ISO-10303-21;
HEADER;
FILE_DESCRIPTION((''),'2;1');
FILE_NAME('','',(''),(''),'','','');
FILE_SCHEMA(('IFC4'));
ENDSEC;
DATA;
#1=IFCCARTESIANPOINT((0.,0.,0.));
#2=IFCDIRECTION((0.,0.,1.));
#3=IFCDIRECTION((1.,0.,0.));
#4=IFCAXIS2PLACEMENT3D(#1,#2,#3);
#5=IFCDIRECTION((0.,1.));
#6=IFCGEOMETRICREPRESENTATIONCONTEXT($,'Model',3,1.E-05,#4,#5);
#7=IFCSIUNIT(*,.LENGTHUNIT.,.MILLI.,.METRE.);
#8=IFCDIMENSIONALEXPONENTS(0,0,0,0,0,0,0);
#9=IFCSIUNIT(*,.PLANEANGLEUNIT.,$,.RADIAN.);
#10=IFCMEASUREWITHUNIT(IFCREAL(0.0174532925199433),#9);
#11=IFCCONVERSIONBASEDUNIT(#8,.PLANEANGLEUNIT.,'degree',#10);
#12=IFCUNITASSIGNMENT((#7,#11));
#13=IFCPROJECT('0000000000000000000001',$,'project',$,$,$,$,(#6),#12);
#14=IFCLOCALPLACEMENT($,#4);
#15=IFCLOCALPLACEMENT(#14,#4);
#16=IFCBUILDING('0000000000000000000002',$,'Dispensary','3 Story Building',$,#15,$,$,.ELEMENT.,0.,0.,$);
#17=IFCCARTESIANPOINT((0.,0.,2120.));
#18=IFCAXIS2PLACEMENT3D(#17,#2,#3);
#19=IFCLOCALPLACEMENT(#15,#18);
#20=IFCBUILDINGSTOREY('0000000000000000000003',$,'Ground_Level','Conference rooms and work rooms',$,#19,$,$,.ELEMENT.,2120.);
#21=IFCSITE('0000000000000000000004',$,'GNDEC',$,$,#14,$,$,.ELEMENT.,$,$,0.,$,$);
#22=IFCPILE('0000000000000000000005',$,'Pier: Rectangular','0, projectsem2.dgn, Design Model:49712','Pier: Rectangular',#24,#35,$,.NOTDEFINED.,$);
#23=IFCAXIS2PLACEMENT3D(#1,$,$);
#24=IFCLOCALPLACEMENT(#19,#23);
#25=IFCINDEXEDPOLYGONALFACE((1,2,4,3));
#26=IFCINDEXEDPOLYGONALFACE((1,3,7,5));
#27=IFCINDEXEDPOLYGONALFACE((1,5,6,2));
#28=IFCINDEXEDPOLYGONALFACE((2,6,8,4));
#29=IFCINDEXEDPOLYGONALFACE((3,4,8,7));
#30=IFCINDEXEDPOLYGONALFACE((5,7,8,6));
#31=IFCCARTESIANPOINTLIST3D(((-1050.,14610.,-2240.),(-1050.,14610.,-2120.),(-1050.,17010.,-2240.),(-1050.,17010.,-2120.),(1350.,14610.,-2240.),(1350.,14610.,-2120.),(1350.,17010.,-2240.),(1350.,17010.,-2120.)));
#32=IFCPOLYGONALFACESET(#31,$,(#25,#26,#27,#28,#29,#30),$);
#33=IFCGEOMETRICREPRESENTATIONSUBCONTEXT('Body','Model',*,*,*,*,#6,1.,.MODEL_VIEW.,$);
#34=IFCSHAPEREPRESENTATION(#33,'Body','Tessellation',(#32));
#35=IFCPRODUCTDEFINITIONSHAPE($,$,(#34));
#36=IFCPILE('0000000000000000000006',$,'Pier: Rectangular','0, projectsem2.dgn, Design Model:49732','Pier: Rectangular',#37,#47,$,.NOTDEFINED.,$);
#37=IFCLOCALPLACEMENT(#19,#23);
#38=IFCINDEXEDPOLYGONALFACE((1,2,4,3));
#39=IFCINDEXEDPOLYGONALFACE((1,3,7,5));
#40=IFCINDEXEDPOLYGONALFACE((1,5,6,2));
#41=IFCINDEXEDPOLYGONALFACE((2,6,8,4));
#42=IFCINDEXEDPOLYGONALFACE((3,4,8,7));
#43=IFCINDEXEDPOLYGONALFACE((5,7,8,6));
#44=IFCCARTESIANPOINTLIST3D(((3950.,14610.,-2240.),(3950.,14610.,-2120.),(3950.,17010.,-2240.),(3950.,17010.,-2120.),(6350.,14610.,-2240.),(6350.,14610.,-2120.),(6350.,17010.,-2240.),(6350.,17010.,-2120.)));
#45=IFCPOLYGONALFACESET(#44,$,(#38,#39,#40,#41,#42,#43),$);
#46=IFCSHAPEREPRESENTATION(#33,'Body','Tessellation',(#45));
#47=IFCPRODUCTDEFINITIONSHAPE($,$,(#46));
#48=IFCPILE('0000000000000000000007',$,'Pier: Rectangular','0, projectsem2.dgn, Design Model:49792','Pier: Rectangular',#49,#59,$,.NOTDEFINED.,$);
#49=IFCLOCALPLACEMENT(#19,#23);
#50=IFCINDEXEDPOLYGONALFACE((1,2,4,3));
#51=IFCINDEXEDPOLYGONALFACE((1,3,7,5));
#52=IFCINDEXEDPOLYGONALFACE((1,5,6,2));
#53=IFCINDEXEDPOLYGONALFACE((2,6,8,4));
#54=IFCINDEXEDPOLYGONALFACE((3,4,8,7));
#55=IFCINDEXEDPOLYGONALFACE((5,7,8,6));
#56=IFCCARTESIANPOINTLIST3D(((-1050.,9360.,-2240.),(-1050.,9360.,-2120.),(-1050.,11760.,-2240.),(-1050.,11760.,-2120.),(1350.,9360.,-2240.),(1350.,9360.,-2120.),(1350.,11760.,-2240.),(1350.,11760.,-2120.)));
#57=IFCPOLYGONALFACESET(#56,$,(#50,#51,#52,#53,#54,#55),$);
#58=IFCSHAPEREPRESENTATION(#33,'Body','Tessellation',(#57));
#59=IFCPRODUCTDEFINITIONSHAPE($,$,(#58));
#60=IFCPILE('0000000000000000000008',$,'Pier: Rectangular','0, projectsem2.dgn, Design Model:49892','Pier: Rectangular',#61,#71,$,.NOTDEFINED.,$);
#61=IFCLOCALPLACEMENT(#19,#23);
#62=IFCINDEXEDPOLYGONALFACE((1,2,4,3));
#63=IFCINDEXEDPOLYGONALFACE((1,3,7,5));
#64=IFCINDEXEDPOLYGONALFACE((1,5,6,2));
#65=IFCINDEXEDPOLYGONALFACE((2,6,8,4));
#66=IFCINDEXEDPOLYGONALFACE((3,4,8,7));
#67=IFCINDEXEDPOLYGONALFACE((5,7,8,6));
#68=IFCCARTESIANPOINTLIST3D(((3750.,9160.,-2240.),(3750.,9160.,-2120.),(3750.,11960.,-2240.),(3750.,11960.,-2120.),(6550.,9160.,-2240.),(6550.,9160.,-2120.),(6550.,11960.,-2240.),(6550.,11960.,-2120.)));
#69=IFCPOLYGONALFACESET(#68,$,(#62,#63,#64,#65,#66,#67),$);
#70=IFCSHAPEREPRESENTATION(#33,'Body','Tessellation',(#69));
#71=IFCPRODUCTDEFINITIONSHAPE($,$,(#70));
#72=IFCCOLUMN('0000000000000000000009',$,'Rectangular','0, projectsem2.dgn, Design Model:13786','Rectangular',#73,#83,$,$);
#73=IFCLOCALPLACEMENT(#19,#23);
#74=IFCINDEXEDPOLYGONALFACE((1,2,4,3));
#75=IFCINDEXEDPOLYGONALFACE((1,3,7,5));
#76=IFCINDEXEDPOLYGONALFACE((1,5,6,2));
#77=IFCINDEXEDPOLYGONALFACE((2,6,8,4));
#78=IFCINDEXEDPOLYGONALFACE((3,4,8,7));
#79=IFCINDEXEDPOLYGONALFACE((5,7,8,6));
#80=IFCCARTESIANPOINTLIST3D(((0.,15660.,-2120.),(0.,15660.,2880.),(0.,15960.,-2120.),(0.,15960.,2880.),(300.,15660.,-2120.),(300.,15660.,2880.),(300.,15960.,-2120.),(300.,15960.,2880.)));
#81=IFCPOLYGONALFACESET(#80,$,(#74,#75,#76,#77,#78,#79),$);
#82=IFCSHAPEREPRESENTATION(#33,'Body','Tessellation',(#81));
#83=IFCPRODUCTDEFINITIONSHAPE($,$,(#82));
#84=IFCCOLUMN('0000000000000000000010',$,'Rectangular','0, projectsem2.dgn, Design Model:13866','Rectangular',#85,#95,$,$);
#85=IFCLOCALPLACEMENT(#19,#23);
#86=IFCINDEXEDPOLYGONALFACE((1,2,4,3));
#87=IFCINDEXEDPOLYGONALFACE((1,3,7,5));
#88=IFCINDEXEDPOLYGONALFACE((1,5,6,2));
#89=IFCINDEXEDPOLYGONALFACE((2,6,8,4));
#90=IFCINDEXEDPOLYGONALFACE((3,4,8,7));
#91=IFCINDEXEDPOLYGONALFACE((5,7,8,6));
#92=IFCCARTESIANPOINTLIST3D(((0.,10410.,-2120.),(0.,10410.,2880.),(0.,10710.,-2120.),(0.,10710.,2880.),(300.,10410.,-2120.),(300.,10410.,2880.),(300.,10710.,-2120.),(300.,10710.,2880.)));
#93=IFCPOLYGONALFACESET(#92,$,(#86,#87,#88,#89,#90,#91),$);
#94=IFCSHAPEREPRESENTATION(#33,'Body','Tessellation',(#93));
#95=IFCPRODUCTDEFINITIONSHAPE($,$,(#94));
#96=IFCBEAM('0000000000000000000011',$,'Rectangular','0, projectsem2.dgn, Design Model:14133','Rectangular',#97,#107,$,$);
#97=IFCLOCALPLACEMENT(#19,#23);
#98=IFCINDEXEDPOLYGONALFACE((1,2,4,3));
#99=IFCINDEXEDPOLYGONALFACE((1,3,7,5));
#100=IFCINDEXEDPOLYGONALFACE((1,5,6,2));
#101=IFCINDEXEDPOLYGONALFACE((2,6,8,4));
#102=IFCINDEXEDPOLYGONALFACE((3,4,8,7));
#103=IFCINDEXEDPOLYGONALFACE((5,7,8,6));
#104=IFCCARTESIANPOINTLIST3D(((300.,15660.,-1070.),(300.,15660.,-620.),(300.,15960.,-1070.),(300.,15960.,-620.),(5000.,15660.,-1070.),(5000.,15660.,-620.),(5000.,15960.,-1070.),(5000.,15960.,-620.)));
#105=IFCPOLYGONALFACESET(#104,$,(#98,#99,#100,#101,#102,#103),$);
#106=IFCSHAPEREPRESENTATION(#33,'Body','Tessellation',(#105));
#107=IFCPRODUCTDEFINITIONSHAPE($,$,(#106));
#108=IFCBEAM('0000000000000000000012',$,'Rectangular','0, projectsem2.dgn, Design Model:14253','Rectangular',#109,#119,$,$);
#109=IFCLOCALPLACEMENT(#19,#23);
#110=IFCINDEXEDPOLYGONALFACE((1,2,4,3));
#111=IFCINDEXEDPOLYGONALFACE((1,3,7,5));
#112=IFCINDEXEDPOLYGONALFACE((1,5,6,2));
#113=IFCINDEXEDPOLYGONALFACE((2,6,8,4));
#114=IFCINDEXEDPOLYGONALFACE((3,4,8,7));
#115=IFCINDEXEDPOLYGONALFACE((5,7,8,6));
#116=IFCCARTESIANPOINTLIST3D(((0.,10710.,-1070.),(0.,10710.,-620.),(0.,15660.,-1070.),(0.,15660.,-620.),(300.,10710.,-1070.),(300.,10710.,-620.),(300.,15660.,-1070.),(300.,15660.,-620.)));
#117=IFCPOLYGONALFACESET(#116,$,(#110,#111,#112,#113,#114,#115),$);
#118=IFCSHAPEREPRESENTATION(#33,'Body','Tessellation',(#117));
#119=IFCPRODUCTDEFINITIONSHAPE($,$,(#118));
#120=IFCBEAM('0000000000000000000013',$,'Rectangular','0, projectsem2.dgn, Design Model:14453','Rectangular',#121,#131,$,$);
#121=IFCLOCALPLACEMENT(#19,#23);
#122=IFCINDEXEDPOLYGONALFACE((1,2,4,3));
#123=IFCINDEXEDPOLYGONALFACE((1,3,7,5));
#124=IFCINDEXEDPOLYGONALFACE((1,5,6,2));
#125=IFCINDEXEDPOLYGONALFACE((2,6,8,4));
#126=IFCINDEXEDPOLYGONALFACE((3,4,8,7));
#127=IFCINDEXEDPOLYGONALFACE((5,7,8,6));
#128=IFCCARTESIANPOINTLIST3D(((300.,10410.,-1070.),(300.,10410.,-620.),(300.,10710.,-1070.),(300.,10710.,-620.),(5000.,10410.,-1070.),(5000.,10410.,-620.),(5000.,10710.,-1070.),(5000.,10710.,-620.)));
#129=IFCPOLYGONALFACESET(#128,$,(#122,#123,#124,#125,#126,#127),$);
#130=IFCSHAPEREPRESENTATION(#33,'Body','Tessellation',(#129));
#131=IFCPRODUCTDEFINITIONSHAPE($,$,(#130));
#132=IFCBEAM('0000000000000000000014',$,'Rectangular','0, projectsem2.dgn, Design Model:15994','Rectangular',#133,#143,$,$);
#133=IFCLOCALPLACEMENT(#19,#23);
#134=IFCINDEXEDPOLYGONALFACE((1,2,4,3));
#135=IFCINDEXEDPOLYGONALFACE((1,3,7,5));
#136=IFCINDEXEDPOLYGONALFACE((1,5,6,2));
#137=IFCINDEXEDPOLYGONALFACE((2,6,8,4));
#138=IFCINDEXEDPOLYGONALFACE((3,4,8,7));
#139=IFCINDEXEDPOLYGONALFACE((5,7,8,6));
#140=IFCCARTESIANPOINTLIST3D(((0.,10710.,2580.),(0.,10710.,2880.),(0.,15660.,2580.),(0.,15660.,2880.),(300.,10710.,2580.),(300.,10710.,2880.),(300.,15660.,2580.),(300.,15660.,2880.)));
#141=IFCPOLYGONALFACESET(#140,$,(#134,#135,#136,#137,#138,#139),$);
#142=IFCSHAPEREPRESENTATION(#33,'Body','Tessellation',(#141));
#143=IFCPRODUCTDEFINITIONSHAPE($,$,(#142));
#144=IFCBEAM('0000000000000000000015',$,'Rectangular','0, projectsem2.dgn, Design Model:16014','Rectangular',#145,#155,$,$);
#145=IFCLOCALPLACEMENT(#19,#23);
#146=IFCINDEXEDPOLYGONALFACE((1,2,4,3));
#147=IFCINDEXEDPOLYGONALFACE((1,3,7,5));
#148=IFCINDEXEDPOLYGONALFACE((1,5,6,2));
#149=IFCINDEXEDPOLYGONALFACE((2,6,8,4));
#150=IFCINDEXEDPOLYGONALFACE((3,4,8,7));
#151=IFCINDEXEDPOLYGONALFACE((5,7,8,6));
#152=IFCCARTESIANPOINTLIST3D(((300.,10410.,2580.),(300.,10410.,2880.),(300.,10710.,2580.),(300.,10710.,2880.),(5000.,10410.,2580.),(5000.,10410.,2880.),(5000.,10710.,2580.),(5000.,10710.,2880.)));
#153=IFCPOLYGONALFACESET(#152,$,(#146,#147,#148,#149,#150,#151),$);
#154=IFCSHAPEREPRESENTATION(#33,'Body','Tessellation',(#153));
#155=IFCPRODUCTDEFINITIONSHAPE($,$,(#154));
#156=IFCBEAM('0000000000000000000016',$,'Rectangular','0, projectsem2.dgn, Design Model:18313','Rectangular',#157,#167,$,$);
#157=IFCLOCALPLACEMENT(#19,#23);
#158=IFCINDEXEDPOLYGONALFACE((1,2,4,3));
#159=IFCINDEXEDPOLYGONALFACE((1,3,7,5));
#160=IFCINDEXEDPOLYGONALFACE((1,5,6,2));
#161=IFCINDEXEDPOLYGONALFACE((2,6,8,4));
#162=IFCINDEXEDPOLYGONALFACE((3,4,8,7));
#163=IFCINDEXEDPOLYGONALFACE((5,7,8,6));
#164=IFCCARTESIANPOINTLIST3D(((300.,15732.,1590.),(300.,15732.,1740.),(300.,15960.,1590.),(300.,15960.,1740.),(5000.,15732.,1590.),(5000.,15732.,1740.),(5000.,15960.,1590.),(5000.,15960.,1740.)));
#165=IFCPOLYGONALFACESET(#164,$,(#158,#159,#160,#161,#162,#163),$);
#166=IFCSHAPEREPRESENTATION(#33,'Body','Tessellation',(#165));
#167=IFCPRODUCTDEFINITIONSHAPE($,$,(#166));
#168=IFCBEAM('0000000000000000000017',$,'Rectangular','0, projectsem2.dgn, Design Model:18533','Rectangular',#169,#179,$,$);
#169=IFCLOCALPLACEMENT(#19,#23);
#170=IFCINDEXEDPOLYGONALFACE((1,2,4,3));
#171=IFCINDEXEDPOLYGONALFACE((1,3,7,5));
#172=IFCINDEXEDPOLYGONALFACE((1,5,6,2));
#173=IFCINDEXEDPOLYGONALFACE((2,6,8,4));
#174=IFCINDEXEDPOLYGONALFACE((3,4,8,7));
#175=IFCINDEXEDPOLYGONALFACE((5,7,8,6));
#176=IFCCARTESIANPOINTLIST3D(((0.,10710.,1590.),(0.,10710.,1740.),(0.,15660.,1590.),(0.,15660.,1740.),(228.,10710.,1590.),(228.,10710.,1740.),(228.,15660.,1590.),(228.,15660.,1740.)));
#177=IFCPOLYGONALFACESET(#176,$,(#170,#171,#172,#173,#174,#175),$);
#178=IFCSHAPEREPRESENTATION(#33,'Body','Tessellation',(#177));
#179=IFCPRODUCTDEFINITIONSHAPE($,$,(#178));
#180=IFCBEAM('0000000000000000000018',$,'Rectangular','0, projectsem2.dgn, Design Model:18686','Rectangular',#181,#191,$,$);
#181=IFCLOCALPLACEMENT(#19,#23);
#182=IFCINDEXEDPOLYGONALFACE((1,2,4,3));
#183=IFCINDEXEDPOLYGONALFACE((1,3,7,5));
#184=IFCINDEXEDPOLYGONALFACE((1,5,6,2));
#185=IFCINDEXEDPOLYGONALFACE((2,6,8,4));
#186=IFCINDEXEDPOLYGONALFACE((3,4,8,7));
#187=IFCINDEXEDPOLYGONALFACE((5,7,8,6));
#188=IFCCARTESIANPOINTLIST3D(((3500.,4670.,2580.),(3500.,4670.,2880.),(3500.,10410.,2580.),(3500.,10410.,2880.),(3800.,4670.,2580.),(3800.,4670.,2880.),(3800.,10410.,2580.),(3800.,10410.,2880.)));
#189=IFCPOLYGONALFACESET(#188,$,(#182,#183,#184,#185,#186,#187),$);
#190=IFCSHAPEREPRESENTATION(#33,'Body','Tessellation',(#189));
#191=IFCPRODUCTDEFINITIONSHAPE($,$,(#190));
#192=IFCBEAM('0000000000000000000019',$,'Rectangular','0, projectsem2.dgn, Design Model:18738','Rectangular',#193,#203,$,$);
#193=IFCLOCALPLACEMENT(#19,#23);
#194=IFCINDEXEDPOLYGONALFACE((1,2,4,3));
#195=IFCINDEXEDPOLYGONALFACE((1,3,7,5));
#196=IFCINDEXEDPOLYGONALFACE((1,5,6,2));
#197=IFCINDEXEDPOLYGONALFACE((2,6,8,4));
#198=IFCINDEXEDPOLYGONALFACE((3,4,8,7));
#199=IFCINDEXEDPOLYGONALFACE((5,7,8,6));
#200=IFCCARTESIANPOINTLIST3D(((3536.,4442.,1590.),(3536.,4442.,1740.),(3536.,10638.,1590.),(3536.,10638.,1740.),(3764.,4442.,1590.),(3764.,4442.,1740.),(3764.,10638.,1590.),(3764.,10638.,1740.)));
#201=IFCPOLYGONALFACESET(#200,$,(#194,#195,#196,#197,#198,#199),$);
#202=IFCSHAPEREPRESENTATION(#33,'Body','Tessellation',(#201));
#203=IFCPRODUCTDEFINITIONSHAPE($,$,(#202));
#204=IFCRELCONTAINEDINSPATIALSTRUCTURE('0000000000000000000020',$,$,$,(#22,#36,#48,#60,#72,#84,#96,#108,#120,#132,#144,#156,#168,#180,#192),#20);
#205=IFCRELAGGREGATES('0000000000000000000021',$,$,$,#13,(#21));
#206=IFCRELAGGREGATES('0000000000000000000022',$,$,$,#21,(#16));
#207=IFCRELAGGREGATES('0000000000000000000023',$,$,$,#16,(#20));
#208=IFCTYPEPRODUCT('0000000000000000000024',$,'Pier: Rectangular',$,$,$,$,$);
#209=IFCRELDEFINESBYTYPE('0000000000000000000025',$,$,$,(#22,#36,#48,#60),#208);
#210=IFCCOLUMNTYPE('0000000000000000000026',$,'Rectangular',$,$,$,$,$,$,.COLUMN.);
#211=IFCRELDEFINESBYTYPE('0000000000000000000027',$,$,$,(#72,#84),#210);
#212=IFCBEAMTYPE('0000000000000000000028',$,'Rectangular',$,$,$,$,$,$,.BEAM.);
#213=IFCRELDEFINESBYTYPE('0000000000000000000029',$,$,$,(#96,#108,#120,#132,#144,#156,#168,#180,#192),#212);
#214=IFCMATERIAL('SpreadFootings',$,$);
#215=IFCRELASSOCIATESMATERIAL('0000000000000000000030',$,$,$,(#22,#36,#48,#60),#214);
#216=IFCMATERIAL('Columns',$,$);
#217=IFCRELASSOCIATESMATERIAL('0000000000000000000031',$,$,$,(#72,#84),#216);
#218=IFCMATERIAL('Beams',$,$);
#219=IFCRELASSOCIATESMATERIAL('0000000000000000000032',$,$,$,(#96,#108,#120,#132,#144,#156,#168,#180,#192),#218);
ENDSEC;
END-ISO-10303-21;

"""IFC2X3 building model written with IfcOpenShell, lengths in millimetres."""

from ifc_helpers import new_model, entity, si_unit, converted_unit, direction, frame, frame_2d, origin_with_axes, place, context, subcontext, project, spatial, rectangle, extrude, material, type_object, element, save


model = new_model("IFC2X3")

# Units and contexts
model_context = context("Model", 3, precision=1e-05, world=origin_with_axes(), true_north=direction((0.0, 1.0)))
body_context = subcontext(model_context, "Body", "Model", "MODEL_VIEW", scale=1.0)
ifc_project = project(units=[si_unit("LENGTHUNIT", "METRE", prefix="MILLI"), converted_unit("PLANEANGLEUNIT", "degree", entity("IfcReal", 0.0174532925199433), si_unit("PLANEANGLEUNIT", "RADIAN"), dimensions=[0, 0, 0, 0, 0, 0, 0])], contexts=[model_context])

# Site, building, storey
site_placement = place(None, origin_with_axes())
site = spatial("IfcSite", under=ifc_project, at=site_placement, Name="GNDEC", CompositionType="ELEMENT", RefElevation=0.0)
building_placement = place(site_placement, origin_with_axes())
building = spatial("IfcBuilding", under=site, at=building_placement, Name="Dispensary", Description="3 Story Building", CompositionType="ELEMENT", ElevationOfRefHeight=0.0, ElevationOfTerrain=0.0)
storey_placement = place(building_placement, frame((0.0, 0.0, 2120.0), z_axis=(0.0, 0.0, 1.0), x_axis=(1.0, 0.0, 0.0)))
storey = spatial("IfcBuildingStorey", under=building, at=storey_placement, Name="Ground_Level", Description="Conference rooms and work rooms", CompositionType="ELEMENT", Elevation=2120.0)

# Piles
ifc_material_1 = material(Name="SpreadFootings")
type_product = type_object("IfcTypeProduct", Name="Pier: Rectangular")
for number, where, z_axis, x_axis, name, description in (
    (1, (-1050.0, 17010.0, -2240.0), (0.0, 0.0, 1.0), (0.0, -1.0, 0.0), "Pier: Rectangular", "0, projectsem2.dgn, Design Model:49712"),
    (2, (3950.0, 17010.0, -2240.0), (0.0, 0.0, 1.0), (0.0, -1.0, 0.0), "Pier: Rectangular", "0, projectsem2.dgn, Design Model:49732"),
    (3, (-1050.0, 11760.0, -2240.0), (0.0, 0.0, 1.0), (0.0, -1.0, 0.0), "Pier: Rectangular", "0, projectsem2.dgn, Design Model:49792"),
):
    element("IfcPile", number, at=place(storey_placement, frame(where, z_axis=z_axis, x_axis=x_axis)), inside=storey, type_object=type_product, material=ifc_material_1, Name=name, Description=description, ObjectType="Pier: Rectangular", PredefinedType="NOTDEFINED", context=body_context, shape_type="SweptSolid", body=[
        extrude(rectangle(XDim=2400.0, YDim=2400.0, at=frame_2d((1200.0, 1200.0), x_axis=(0.0, 1.0))), origin_with_axes(), (0.0, 0.0, 1.0), 120.0),
    ])
pile_placement = place(storey_placement, frame((3750.0, 11960.0, -2240.0), z_axis=(0.0, 0.0, 1.0), x_axis=(0.0, -1.0, 0.0)))
element("IfcPile", 4, at=pile_placement, inside=storey, type_object=type_product, material=ifc_material_1, Name="Pier: Rectangular", Description="0, projectsem2.dgn, Design Model:49892", ObjectType="Pier: Rectangular", PredefinedType="NOTDEFINED", context=body_context, shape_type="SweptSolid", body=[
    extrude(rectangle(XDim=2800.0, YDim=2800.0, at=frame_2d((1400.0, 1400.0), x_axis=(0.0, 1.0))), origin_with_axes(), (0.0, 0.0, 1.0), 120.0),
])

# Columns
ifc_material_2 = material(Name="Columns")
column_type = type_object("IfcColumnType", Name="Rectangular", PredefinedType="COLUMN")
for number, where, z_axis, x_axis, name, description in (
    (5, (0.0, 15960.0, -2120.0), (0.0, 0.0, 1.0), (0.0, -1.0, 0.0), "Rectangular", "0, projectsem2.dgn, Design Model:13786"),
    (6, (0.0, 10710.0, -2120.0), (0.0, 0.0, 1.0), (0.0, -1.0, 0.0), "Rectangular", "0, projectsem2.dgn, Design Model:13866"),
):
    element("IfcColumn", number, at=place(storey_placement, frame(where, z_axis=z_axis, x_axis=x_axis)), inside=storey, type_object=column_type, material=ifc_material_2, Name=name, Description=description, ObjectType="Rectangular", context=body_context, shape_type="SweptSolid", body=[
        extrude(rectangle(XDim=300.0, YDim=300.0, at=frame_2d((150.0, 150.0), x_axis=(0.0, 1.0))), origin_with_axes(), (0.0, 0.0, 1.0), 5000.0),
    ])

# Beams
ifc_material_3 = material(Name="Beams")
beam_type = type_object("IfcBeamType", Name="Rectangular", PredefinedType="BEAM")
beam_1_placement = place(storey_placement, frame((300.0, 15960.0, -1070.0), z_axis=(1.0, 0.0, 0.0), x_axis=(0.0, 0.0, 1.0)))
element("IfcBeam", 7, at=beam_1_placement, inside=storey, type_object=beam_type, material=ifc_material_3, Name="Rectangular", Description="0, projectsem2.dgn, Design Model:14133", ObjectType="Rectangular", context=body_context, shape_type="SweptSolid", body=[
    extrude(rectangle(XDim=300.0, YDim=450.0, at=frame_2d((225.0, 150.0), x_axis=(0.0, 1.0))), origin_with_axes(), (0.0, 0.0, 1.0), 4700.0),
])
beam_2_placement = place(storey_placement, frame((300.0, 15660.0, -1070.0), z_axis=(0.0, -1.0, 0.0), x_axis=(0.0, 0.0, 1.0)))
element("IfcBeam", 8, at=beam_2_placement, inside=storey, type_object=beam_type, material=ifc_material_3, Name="Rectangular", Description="0, projectsem2.dgn, Design Model:14253", ObjectType="Rectangular", context=body_context, shape_type="SweptSolid", body=[
    extrude(rectangle(XDim=300.0, YDim=450.0, at=frame_2d((225.0, 150.0), x_axis=(0.0, 1.0))), origin_with_axes(), (0.0, 0.0, 1.0), 4950.0),
])
beam_3_placement = place(storey_placement, frame((5000.0, 10410.0, -1070.0), z_axis=(-1.0, 0.0, 0.0), x_axis=(0.0, 0.0, 1.0)))
element("IfcBeam", 9, at=beam_3_placement, inside=storey, type_object=beam_type, material=ifc_material_3, Name="Rectangular", Description="0, projectsem2.dgn, Design Model:14453", ObjectType="Rectangular", context=body_context, shape_type="SweptSolid", body=[
    extrude(rectangle(XDim=300.0, YDim=450.0, at=frame_2d((225.0, 150.0), x_axis=(0.0, 1.0))), origin_with_axes(), (0.0, 0.0, 1.0), 4700.0),
])
beam_4_placement = place(storey_placement, frame((300.0, 15660.0, 2580.0), z_axis=(0.0, -1.0, 0.0), x_axis=(0.0, 0.0, 1.0)))
element("IfcBeam", 10, at=beam_4_placement, inside=storey, type_object=beam_type, material=ifc_material_3, Name="Rectangular", Description="0, projectsem2.dgn, Design Model:15994", ObjectType="Rectangular", context=body_context, shape_type="SweptSolid", body=[
    extrude(rectangle(XDim=300.0, YDim=300.0, at=frame_2d((150.0, 150.0), x_axis=(0.0, 1.0))), origin_with_axes(), (0.0, 0.0, 1.0), 4950.0),
])
for number, where, z_axis, x_axis, name in (
    (11, (300.0, 10710.0, 2580.0), (1.0, 0.0, 0.0), (0.0, 0.0, 1.0), "Rectangular"),
):
    element("IfcBeam", number, at=place(storey_placement, frame(where, z_axis=z_axis, x_axis=x_axis)), inside=storey, type_object=beam_type, material=ifc_material_3, Name=name, Description="0, projectsem2.dgn, Design Model:16014", ObjectType="Rectangular", context=body_context, shape_type="SweptSolid", body=[
        extrude(rectangle(XDim=300.0, YDim=300.0, at=frame_2d((150.0, 150.0), x_axis=(0.0, 1.0))), origin_with_axes(), (0.0, 0.0, 1.0), 4700.0),
    ])
beam_5_placement = place(storey_placement, frame((300.0, 15732.0, 1590.0), z_axis=(1.0, 0.0, 0.0), x_axis=(0.0, 1.0, 0.0)))
element("IfcBeam", 12, at=beam_5_placement, inside=storey, type_object=beam_type, material=ifc_material_3, Name="Rectangular", Description="0, projectsem2.dgn, Design Model:18313", ObjectType="Rectangular", context=body_context, shape_type="SweptSolid", body=[
    extrude(rectangle(XDim=150.0, YDim=228.0, at=frame_2d((114.0, 75.0), x_axis=(0.0, 1.0))), origin_with_axes(), (0.0, 0.0, 1.0), 4700.0),
])
beam_6_placement = place(storey_placement, frame((0.0, 15660.0, 1590.0), z_axis=(0.0, -1.0, 0.0), x_axis=(1.0, 0.0, 0.0)))
element("IfcBeam", 13, at=beam_6_placement, inside=storey, type_object=beam_type, material=ifc_material_3, Name="Rectangular", Description="0, projectsem2.dgn, Design Model:18533", ObjectType="Rectangular", context=body_context, shape_type="SweptSolid", body=[
    extrude(rectangle(XDim=150.0, YDim=228.0, at=frame_2d((114.0, 75.0), x_axis=(0.0, 1.0))), origin_with_axes(), (0.0, 0.0, 1.0), 4950.0),
])
beam_7_placement = place(storey_placement, frame((3800.0, 10410.0, 2580.0), z_axis=(0.0, -1.0, 0.0), x_axis=(0.0, 0.0, 1.0)))
element("IfcBeam", 14, at=beam_7_placement, inside=storey, type_object=beam_type, material=ifc_material_3, Name="Rectangular", Description="0, projectsem2.dgn, Design Model:18686", ObjectType="Rectangular", context=body_context, shape_type="SweptSolid", body=[
    extrude(rectangle(XDim=300.0, YDim=300.0, at=frame_2d((150.0, 150.0), x_axis=(0.0, 1.0))), origin_with_axes(), (0.0, 0.0, 1.0), 5740.0),
])
beam_8_placement = place(storey_placement, frame((3536.0, 10638.0, 1590.0), z_axis=(0.0, -1.0, 0.0), x_axis=(1.0, 0.0, 0.0)))
element("IfcBeam", 15, at=beam_8_placement, inside=storey, type_object=beam_type, material=ifc_material_3, Name="Rectangular", Description="0, projectsem2.dgn, Design Model:18738", ObjectType="Rectangular", context=body_context, shape_type="SweptSolid", body=[
    extrude(rectangle(XDim=150.0, YDim=228.0, at=frame_2d((114.0, 75.0), x_axis=(0.0, 1.0))), origin_with_axes(), (0.0, 0.0, 1.0), 6196.0),
])

save(model, "model.ifc")
